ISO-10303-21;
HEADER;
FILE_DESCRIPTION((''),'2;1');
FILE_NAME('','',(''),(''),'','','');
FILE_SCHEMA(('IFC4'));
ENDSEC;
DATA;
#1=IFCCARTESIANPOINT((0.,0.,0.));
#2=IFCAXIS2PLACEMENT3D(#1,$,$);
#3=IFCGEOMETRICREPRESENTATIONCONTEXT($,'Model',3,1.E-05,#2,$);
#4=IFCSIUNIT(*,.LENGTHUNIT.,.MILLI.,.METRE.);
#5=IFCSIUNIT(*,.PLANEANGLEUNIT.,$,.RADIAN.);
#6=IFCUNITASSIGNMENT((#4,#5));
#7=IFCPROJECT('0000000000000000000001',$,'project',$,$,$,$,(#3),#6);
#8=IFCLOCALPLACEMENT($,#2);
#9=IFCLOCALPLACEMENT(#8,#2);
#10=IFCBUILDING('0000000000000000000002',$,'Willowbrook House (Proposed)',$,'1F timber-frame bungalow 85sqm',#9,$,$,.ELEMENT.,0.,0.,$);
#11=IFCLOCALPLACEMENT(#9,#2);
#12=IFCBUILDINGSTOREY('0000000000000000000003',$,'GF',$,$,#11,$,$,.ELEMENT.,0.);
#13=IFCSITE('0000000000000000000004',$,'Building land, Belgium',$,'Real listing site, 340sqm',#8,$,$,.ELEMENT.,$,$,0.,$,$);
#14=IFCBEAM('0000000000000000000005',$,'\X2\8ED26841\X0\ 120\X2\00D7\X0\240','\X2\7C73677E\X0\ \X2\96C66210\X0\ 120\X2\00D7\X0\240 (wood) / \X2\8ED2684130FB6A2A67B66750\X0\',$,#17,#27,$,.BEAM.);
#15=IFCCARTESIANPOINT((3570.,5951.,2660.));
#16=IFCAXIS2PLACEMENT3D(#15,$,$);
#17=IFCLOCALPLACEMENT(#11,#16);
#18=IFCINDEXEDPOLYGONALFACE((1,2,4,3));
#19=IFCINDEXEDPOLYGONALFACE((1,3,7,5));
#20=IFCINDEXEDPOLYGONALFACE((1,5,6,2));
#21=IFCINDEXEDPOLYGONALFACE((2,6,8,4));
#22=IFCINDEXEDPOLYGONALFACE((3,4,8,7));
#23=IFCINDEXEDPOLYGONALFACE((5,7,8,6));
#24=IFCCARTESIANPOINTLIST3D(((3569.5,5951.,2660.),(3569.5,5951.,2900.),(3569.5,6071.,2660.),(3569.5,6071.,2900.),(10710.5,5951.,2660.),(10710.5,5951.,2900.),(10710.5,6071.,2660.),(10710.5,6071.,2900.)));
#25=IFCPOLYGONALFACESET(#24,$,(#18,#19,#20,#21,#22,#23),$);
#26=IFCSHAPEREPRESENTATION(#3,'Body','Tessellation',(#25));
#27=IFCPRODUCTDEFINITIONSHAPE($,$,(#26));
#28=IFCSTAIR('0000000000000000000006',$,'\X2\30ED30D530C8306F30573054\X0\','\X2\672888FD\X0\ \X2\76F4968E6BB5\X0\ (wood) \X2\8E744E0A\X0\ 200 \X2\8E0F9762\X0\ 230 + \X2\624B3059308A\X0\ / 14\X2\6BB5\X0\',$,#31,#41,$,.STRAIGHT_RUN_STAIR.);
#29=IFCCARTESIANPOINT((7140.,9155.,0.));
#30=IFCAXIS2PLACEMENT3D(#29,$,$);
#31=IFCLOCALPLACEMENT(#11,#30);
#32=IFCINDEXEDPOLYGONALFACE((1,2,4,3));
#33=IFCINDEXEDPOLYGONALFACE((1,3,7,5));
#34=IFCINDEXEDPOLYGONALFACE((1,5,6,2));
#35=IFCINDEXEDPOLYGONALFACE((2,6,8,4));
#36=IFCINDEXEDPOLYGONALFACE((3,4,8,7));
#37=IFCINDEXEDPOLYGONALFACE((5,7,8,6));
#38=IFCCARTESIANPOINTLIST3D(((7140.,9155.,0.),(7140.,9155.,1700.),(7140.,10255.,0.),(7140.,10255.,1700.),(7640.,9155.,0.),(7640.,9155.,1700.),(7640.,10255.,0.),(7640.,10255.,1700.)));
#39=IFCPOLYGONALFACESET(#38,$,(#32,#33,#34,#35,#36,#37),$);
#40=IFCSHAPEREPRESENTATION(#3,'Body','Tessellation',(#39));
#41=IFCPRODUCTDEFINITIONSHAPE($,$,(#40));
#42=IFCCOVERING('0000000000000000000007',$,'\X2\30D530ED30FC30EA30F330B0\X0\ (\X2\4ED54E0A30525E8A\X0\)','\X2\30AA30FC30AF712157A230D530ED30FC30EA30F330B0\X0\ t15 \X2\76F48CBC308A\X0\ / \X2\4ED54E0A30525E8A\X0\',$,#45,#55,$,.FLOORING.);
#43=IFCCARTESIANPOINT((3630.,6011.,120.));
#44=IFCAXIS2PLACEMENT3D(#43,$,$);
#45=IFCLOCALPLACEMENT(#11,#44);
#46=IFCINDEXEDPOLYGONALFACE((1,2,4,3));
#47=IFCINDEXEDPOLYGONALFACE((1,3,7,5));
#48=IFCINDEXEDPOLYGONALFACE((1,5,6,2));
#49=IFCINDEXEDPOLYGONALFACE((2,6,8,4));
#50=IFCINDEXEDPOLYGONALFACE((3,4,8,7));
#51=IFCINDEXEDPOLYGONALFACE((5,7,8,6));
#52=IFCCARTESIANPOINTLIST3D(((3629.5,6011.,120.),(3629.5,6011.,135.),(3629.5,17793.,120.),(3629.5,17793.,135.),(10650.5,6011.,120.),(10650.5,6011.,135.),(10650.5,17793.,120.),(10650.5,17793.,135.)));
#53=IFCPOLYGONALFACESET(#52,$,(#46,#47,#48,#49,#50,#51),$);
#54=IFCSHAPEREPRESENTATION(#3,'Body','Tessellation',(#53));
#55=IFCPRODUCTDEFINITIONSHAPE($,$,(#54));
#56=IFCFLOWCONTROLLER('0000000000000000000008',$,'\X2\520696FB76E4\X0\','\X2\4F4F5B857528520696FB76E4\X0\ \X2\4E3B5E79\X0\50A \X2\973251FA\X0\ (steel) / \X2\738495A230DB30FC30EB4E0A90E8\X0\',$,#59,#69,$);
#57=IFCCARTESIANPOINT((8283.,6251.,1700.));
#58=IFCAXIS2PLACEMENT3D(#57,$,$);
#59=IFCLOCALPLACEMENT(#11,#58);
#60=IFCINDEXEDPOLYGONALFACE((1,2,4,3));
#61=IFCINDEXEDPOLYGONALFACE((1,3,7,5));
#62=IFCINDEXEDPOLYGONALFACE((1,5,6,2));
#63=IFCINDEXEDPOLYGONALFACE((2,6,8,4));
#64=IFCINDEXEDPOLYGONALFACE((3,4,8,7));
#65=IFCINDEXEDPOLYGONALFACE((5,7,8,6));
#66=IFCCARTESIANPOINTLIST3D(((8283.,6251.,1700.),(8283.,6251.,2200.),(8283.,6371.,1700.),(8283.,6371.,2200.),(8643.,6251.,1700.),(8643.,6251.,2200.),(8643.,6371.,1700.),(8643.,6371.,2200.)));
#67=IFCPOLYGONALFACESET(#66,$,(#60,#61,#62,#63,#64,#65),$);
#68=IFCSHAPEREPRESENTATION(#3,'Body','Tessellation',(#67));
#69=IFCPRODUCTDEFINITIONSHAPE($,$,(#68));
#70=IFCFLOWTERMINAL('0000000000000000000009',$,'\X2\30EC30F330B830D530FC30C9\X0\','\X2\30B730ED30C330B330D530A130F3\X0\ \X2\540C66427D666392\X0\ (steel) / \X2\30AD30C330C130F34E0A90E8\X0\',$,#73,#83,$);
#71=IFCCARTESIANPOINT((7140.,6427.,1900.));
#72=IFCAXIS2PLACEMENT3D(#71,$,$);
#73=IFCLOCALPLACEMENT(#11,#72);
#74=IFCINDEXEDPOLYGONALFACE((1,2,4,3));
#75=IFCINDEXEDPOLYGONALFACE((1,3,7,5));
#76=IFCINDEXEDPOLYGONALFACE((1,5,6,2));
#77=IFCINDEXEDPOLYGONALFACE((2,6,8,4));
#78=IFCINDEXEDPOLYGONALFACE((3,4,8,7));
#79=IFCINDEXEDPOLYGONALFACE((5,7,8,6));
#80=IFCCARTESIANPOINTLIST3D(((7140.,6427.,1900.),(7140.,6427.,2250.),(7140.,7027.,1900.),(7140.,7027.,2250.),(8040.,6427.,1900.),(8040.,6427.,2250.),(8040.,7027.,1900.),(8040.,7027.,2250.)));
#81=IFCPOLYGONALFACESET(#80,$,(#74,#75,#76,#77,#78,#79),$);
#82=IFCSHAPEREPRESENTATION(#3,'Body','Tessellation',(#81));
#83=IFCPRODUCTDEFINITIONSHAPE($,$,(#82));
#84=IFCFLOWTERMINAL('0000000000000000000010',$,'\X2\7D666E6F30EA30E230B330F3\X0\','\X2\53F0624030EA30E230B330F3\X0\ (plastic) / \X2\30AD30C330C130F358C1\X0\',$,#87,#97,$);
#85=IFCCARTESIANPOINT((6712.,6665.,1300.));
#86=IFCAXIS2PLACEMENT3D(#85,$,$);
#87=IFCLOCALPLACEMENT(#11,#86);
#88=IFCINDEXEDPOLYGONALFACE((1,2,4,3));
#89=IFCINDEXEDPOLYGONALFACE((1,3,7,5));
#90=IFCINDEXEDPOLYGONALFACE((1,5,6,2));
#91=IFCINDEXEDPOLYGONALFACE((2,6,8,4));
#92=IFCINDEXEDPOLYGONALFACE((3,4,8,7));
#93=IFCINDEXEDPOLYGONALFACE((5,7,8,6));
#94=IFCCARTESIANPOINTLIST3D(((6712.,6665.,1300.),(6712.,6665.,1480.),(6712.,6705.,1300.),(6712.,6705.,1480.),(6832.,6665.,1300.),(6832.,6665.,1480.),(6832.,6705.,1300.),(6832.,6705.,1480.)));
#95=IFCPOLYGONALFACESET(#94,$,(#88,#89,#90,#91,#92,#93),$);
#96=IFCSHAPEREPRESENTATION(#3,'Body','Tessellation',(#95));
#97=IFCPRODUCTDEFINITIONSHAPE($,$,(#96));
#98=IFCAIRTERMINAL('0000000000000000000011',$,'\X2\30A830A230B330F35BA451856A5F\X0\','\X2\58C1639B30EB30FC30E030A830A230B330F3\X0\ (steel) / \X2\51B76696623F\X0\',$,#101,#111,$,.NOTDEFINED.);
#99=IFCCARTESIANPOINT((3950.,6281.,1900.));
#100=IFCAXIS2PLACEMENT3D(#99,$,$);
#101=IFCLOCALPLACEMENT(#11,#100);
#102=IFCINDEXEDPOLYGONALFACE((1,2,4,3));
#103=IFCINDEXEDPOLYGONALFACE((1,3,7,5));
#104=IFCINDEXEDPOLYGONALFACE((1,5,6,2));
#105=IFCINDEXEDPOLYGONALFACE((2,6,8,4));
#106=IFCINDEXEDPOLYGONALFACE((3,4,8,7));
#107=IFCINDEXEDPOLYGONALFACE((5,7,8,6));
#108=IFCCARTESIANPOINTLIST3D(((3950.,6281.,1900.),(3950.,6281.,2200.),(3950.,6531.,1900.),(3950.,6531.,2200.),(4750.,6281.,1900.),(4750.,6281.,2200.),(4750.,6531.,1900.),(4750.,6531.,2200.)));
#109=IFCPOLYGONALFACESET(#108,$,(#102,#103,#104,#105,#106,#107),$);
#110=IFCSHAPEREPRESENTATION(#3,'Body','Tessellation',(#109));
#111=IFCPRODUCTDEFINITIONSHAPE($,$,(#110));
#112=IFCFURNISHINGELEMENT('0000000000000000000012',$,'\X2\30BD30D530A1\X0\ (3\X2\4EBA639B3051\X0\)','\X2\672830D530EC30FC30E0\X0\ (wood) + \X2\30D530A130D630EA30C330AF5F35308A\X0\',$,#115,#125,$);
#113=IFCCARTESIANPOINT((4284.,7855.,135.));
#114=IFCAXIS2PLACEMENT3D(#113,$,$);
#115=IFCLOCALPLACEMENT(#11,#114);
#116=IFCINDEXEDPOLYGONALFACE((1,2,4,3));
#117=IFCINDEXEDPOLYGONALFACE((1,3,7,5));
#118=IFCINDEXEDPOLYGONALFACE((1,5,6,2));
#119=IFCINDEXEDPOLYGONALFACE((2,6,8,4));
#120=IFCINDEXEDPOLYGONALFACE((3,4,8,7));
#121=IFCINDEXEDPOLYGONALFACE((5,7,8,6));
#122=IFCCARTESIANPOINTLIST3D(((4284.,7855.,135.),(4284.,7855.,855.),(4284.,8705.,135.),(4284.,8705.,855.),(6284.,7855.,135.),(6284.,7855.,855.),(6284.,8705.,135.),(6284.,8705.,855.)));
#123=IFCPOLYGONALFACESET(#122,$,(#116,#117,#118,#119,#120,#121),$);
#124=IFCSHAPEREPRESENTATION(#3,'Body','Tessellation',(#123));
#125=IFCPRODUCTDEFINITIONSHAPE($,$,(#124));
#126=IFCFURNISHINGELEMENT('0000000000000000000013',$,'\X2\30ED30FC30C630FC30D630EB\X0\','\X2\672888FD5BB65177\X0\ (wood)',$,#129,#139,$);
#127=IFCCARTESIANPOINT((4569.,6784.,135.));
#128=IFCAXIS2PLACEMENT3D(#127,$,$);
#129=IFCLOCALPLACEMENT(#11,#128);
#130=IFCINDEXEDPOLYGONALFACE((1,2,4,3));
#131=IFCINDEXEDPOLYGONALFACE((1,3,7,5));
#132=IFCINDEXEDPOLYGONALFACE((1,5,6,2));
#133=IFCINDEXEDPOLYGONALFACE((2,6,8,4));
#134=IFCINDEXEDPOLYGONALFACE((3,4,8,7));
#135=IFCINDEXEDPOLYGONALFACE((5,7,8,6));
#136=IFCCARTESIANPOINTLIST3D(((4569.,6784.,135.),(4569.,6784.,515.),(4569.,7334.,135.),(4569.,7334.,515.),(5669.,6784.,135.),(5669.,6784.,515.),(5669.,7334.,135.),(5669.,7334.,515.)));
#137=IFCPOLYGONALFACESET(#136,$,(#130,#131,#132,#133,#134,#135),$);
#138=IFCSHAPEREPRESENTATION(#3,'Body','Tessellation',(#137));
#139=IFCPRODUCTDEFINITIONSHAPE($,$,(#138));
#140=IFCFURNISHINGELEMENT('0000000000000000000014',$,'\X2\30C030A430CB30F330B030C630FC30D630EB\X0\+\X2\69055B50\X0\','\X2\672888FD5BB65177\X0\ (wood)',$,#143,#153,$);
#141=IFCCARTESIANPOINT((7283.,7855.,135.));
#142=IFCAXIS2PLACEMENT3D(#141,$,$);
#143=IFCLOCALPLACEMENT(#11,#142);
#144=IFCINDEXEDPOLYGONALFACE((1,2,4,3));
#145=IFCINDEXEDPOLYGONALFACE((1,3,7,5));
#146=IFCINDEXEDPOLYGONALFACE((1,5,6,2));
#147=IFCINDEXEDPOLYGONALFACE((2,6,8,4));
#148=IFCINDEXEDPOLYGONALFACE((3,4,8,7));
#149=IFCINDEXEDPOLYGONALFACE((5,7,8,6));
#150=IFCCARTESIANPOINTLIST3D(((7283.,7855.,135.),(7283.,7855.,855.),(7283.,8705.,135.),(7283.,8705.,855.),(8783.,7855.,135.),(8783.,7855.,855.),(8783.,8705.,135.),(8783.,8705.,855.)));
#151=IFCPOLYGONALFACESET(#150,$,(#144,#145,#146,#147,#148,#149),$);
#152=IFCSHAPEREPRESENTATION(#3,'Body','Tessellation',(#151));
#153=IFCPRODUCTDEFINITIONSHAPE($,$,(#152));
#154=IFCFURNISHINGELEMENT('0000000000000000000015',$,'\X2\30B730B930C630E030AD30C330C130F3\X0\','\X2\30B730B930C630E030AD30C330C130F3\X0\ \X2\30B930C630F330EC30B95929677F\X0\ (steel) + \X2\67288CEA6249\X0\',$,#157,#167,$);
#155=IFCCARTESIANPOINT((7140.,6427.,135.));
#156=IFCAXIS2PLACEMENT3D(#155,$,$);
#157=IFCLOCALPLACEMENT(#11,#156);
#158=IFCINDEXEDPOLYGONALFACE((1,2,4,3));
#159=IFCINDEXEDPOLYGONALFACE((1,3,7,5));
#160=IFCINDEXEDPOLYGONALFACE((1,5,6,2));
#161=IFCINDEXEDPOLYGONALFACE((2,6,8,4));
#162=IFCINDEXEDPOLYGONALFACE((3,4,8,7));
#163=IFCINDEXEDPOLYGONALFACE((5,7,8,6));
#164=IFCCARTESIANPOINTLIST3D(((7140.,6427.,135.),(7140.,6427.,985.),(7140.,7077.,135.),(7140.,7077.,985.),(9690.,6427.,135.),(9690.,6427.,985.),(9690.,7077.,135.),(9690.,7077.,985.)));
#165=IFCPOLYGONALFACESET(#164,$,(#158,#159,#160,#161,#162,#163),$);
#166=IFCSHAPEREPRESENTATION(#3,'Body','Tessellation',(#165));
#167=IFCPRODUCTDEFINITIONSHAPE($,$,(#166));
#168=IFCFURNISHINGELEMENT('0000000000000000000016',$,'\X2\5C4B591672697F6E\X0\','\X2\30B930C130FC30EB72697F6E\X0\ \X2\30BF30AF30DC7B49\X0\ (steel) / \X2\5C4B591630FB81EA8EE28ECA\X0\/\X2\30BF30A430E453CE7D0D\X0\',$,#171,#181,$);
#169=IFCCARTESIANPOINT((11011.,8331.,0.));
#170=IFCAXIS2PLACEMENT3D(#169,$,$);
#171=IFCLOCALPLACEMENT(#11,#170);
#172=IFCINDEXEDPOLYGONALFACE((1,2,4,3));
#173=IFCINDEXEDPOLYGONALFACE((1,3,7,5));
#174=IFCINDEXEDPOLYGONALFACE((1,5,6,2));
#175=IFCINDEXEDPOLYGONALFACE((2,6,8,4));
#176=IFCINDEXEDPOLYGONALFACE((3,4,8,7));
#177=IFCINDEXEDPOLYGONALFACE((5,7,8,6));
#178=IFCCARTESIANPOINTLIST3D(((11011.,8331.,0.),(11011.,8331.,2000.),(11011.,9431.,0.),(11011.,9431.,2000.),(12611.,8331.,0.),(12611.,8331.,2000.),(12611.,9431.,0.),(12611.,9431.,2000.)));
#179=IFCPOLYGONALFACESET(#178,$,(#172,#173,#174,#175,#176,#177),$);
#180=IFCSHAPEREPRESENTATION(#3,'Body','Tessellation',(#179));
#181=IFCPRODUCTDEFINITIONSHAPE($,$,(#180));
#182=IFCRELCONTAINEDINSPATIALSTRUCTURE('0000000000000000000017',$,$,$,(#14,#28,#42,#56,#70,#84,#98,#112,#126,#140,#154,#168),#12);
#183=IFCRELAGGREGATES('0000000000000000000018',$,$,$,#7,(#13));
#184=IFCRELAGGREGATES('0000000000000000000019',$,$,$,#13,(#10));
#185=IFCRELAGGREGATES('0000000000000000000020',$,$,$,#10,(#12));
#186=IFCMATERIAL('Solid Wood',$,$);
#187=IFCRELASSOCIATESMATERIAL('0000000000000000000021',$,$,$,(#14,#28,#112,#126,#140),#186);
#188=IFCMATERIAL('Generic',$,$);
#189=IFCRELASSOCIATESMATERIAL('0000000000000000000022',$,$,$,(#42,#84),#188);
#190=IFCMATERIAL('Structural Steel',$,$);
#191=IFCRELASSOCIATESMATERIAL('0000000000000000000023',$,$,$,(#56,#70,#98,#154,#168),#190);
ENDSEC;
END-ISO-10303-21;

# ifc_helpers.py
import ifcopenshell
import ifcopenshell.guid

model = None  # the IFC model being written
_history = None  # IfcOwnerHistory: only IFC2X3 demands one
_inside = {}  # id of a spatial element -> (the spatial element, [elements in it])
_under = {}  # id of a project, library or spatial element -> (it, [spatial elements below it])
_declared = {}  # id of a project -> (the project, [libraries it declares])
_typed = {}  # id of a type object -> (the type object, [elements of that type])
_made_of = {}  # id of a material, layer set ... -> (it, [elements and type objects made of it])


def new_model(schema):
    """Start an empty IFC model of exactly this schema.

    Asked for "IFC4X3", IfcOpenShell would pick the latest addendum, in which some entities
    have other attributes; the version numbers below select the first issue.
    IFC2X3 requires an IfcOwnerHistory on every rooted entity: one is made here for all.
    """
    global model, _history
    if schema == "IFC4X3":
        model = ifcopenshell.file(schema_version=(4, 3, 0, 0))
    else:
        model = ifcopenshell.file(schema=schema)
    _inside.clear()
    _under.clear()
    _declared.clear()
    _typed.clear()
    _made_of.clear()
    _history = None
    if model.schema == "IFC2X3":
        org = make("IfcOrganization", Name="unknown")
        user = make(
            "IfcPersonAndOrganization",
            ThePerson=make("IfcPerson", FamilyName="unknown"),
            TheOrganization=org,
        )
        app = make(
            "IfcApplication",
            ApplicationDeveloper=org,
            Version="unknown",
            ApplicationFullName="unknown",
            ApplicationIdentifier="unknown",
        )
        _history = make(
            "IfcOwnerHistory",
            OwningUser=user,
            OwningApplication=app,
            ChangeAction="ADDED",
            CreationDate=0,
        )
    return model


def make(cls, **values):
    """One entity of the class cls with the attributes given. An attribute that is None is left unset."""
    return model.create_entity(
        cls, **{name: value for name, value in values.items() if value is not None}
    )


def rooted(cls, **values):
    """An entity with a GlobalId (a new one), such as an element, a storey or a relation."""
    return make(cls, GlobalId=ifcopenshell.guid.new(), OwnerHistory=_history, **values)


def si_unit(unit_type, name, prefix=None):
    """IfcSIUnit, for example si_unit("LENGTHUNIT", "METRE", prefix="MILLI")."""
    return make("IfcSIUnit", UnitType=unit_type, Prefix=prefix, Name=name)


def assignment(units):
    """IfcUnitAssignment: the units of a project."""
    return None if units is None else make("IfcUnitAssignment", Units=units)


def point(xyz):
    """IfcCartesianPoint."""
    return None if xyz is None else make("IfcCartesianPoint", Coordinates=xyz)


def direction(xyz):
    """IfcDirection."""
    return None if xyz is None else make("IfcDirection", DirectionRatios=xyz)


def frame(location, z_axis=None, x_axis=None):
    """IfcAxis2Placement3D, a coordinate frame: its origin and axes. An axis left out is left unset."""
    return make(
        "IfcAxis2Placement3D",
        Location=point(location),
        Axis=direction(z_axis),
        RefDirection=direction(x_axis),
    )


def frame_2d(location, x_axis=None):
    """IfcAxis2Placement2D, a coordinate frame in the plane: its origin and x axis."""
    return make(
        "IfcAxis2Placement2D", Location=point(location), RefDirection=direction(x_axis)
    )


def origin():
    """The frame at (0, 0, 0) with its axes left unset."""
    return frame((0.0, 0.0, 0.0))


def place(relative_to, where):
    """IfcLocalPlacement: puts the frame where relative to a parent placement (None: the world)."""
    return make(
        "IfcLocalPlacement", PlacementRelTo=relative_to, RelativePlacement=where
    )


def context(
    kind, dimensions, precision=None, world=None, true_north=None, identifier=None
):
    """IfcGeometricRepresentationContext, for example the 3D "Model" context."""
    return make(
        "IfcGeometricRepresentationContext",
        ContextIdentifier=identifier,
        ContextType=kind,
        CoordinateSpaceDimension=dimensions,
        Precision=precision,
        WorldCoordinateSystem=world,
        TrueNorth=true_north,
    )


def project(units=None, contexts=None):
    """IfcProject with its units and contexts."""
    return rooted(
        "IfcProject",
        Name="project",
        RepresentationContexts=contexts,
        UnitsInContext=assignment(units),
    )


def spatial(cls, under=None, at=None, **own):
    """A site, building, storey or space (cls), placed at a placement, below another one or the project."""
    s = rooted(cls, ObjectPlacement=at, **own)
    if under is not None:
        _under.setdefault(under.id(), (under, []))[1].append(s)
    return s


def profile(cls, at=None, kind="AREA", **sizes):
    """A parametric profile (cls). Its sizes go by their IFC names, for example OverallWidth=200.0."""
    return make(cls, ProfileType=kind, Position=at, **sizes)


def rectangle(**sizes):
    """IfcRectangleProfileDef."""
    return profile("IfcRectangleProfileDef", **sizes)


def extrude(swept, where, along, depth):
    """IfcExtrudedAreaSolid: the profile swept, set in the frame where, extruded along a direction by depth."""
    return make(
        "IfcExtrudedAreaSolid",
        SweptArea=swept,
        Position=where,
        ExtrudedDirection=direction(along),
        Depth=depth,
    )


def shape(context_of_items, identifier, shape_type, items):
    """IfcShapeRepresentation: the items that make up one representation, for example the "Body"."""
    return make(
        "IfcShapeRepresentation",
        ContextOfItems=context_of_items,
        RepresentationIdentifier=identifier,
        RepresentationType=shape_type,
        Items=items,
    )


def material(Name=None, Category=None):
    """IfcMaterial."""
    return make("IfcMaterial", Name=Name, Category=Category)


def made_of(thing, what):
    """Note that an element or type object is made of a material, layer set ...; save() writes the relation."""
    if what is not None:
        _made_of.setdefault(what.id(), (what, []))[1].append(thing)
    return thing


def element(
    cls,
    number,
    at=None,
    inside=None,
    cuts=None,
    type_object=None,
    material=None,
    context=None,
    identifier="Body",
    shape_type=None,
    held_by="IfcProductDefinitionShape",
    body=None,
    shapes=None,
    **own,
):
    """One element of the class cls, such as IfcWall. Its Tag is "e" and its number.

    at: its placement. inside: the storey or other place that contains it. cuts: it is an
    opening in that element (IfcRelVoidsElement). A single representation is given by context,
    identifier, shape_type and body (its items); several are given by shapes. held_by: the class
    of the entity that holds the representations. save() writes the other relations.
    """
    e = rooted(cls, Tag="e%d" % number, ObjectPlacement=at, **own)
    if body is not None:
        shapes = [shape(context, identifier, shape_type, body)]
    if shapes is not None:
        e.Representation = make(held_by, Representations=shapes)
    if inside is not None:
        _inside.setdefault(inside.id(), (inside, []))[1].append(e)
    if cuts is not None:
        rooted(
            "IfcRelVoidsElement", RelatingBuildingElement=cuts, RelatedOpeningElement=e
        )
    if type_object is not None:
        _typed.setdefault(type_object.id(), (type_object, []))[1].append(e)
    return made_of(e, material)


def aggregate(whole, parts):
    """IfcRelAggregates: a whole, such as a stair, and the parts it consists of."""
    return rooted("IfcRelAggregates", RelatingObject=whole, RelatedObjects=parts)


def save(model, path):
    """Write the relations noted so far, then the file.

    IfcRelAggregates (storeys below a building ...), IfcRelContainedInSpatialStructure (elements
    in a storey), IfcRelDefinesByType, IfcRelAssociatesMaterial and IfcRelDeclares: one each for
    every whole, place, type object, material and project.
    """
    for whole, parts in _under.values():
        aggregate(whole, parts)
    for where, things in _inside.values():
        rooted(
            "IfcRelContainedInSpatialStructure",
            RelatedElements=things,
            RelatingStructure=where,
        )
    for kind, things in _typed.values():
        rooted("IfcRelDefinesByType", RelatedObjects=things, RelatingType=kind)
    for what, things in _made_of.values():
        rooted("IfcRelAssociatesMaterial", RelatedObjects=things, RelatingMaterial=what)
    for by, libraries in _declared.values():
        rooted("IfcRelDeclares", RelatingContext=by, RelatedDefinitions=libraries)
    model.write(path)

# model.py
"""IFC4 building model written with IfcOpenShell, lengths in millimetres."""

from ifc_helpers import new_model, si_unit, frame, frame_2d, origin, place, context, project, spatial, rectangle, extrude, material, element, save


model = new_model("IFC4")

# Units and contexts
model_context = context("Model", 3, precision=1e-05, world=origin())
ifc_project = project(units=[si_unit("LENGTHUNIT", "METRE", prefix="MILLI"), si_unit("PLANEANGLEUNIT", "RADIAN")], contexts=[model_context])

# Site, building, storey
site_placement = place(None, origin())
site = spatial("IfcSite", under=ifc_project, at=site_placement, Name="Building land, Belgium", ObjectType="Real listing site, 340sqm", CompositionType="ELEMENT", RefElevation=0.0)
building_placement = place(site_placement, origin())
building = spatial("IfcBuilding", under=site, at=building_placement, Name="Willowbrook House (Proposed)", ObjectType="1F timber-frame bungalow 85sqm", CompositionType="ELEMENT", ElevationOfRefHeight=0.0, ElevationOfTerrain=0.0)
storey_placement = place(building_placement, origin())
storey = spatial("IfcBuildingStorey", under=building, at=storey_placement, Name="GF", CompositionType="ELEMENT", Elevation=0.0)

# Shared definitions
ifc_material_1 = material(Name="Solid Wood")

# Beam
beam_1_placement = place(storey_placement, frame((3570.0, 5951.0, 2660.0)))
element("IfcBeam", 1, at=beam_1_placement, inside=storey, material=ifc_material_1, Name="軒桁 120×240", Description="米松 集成 120×240 (wood) / 軒桁・横架材", PredefinedType="BEAM", context=model_context, shape_type="SweptSolid", body=[
    extrude(rectangle(XDim=7141.0, YDim=120.0, at=frame_2d((3570.0, 60.0))), frame((3570.0, 5951.0, 2660.0)), (0.0, 0.0, 1.0), 240.0),
])

# Stair
stair_placement = place(storey_placement, frame((7140.0, 9155.0, 0.0)))
element("IfcStair", 2, at=stair_placement, inside=storey, material=ifc_material_1, Name="ロフトはしご", Description="木製 直階段 (wood) 蹴上 200 踏面 230 + 手すり / 14段", PredefinedType="STRAIGHT_RUN_STAIR", context=model_context, shape_type="SweptSolid", body=[
    extrude(rectangle(XDim=500.0, YDim=1100.0, at=frame_2d((250.0, 550.0))), frame((7140.0, 9155.0, 0.0)), (0.0, 0.0, 1.0), 1700.0),
])

# Covering
ifc_material_2 = material(Name="Generic")
covering_placement = place(storey_placement, frame((3630.0, 6011.0, 120.0)))
element("IfcCovering", 3, at=covering_placement, inside=storey, material=ifc_material_2, Name="フローリング (仕上げ床)", Description="オーク無垢フローリング t15 直貼り / 仕上げ床", PredefinedType="FLOORING", context=model_context, shape_type="SweptSolid", body=[
    extrude(rectangle(XDim=7021.0, YDim=11782.0, at=frame_2d((3510.0, 5891.0))), frame((3630.0, 6011.0, 120.0)), (0.0, 0.0, 1.0), 15.0),
])

# Flow controller
ifc_material_3 = material(Name="Structural Steel")
flow_controller_placement = place(storey_placement, frame((8283.0, 6251.0, 1700.0)))
element("IfcFlowController", 4, at=flow_controller_placement, inside=storey, material=ifc_material_3, Name="分電盤", Description="住宅用分電盤 主幹50A 露出 (steel) / 玄関ホール上部", context=model_context, shape_type="SweptSolid", body=[
    extrude(rectangle(XDim=360.0, YDim=120.0, at=frame_2d((180.0, 60.0))), frame((8283.0, 6251.0, 1700.0)), (0.0, 0.0, 1.0), 500.0),
])

# Flow terminals
flow_terminal_1_placement = place(storey_placement, frame((7140.0, 6427.0, 1900.0)))
element("IfcFlowTerminal", 5, at=flow_terminal_1_placement, inside=storey, material=ifc_material_3, Name="レンジフード", Description="シロッコファン 同時給排 (steel) / キッチン上部", context=model_context, shape_type="SweptSolid", body=[
    extrude(rectangle(XDim=900.0, YDim=600.0, at=frame_2d((450.0, 300.0))), frame((7140.0, 6427.0, 1900.0)), (0.0, 0.0, 1.0), 350.0),
])
flow_terminal_2_placement = place(storey_placement, frame((6712.0, 6665.0, 1300.0)))
element("IfcFlowTerminal", 6, at=flow_terminal_2_placement, inside=storey, material=ifc_material_2, Name="給湯リモコン", Description="台所リモコン (plastic) / キッチン壁", context=model_context, shape_type="SweptSolid", body=[
    extrude(rectangle(XDim=120.0, YDim=40.0, at=frame_2d((60.0, 20.0))), frame((6712.0, 6665.0, 1300.0)), (0.0, 0.0, 1.0), 180.0),
])

# Air terminal
air_terminal_placement = place(storey_placement, frame((3950.0, 6281.0, 1900.0)))
element("IfcAirTerminal", 7, at=air_terminal_placement, inside=storey, material=ifc_material_3, Name="エアコン室内機", Description="壁掛ルームエアコン (steel) / 冷暖房", PredefinedType="NOTDEFINED", context=model_context, shape_type="SweptSolid", body=[
    extrude(rectangle(XDim=800.0, YDim=250.0, at=frame_2d((400.0, 125.0))), frame((3950.0, 6281.0, 1900.0)), (0.0, 0.0, 1.0), 300.0),
])

# Furnishing elements
furnishing_1_placement = place(storey_placement, frame((4284.0, 7855.0, 135.0)))
element("IfcFurnishingElement", 8, at=furnishing_1_placement, inside=storey, material=ifc_material_1, Name="ソファ (3人掛け)", Description="木フレーム (wood) + ファブリック張り", context=model_context, shape_type="SweptSolid", body=[
    extrude(rectangle(XDim=2000.0, YDim=850.0, at=frame_2d((1000.0, 425.0))), frame((4284.0, 7855.0, 135.0)), (0.0, 0.0, 1.0), 720.0),
])
furnishing_2_placement = place(storey_placement, frame((4569.0, 6784.0, 135.0)))
element("IfcFurnishingElement", 9, at=furnishing_2_placement, inside=storey, material=ifc_material_1, Name="ローテーブル", Description="木製家具 (wood)", context=model_context, shape_type="SweptSolid", body=[
    extrude(rectangle(XDim=1100.0, YDim=550.0, at=frame_2d((550.0, 275.0))), frame((4569.0, 6784.0, 135.0)), (0.0, 0.0, 1.0), 380.0),
])
furnishing_3_placement = place(storey_placement, frame((7283.0, 7855.0, 135.0)))
element("IfcFurnishingElement", 10, at=furnishing_3_placement, inside=storey, material=ifc_material_1, Name="ダイニングテーブル+椅子", Description="木製家具 (wood)", context=model_context, shape_type="SweptSolid", body=[
    extrude(rectangle(XDim=1500.0, YDim=850.0, at=frame_2d((750.0, 425.0))), frame((7283.0, 7855.0, 135.0)), (0.0, 0.0, 1.0), 720.0),
])
furnishing_4_placement = place(storey_placement, frame((7140.0, 6427.0, 135.0)))
element("IfcFurnishingElement", 11, at=furnishing_4_placement, inside=storey, material=ifc_material_3, Name="システムキッチン", Description="システムキッチン ステンレス天板 (steel) + 木質扉", context=model_context, shape_type="SweptSolid", body=[
    extrude(rectangle(XDim=2550.0, YDim=650.0, at=frame_2d((1275.0, 325.0))), frame((7140.0, 6427.0, 135.0)), (0.0, 0.0, 1.0), 850.0),
])
furnishing_5_placement = place(storey_placement, frame((11011.0, 8331.0, 0.0)))
element("IfcFurnishingElement", 12, at=furnishing_5_placement, inside=storey, material=ifc_material_3, Name="屋外物置", Description="スチール物置 タクボ等 (steel) / 屋外・自転車/タイヤ収納", context=model_context, shape_type="SweptSolid", body=[
    extrude(rectangle(XDim=1600.0, YDim=1100.0, at=frame_2d((800.0, 550.0))), frame((11011.0, 8331.0, 0.0)), (0.0, 0.0, 1.0), 2000.0),
])

save(model, "model.ifc")
